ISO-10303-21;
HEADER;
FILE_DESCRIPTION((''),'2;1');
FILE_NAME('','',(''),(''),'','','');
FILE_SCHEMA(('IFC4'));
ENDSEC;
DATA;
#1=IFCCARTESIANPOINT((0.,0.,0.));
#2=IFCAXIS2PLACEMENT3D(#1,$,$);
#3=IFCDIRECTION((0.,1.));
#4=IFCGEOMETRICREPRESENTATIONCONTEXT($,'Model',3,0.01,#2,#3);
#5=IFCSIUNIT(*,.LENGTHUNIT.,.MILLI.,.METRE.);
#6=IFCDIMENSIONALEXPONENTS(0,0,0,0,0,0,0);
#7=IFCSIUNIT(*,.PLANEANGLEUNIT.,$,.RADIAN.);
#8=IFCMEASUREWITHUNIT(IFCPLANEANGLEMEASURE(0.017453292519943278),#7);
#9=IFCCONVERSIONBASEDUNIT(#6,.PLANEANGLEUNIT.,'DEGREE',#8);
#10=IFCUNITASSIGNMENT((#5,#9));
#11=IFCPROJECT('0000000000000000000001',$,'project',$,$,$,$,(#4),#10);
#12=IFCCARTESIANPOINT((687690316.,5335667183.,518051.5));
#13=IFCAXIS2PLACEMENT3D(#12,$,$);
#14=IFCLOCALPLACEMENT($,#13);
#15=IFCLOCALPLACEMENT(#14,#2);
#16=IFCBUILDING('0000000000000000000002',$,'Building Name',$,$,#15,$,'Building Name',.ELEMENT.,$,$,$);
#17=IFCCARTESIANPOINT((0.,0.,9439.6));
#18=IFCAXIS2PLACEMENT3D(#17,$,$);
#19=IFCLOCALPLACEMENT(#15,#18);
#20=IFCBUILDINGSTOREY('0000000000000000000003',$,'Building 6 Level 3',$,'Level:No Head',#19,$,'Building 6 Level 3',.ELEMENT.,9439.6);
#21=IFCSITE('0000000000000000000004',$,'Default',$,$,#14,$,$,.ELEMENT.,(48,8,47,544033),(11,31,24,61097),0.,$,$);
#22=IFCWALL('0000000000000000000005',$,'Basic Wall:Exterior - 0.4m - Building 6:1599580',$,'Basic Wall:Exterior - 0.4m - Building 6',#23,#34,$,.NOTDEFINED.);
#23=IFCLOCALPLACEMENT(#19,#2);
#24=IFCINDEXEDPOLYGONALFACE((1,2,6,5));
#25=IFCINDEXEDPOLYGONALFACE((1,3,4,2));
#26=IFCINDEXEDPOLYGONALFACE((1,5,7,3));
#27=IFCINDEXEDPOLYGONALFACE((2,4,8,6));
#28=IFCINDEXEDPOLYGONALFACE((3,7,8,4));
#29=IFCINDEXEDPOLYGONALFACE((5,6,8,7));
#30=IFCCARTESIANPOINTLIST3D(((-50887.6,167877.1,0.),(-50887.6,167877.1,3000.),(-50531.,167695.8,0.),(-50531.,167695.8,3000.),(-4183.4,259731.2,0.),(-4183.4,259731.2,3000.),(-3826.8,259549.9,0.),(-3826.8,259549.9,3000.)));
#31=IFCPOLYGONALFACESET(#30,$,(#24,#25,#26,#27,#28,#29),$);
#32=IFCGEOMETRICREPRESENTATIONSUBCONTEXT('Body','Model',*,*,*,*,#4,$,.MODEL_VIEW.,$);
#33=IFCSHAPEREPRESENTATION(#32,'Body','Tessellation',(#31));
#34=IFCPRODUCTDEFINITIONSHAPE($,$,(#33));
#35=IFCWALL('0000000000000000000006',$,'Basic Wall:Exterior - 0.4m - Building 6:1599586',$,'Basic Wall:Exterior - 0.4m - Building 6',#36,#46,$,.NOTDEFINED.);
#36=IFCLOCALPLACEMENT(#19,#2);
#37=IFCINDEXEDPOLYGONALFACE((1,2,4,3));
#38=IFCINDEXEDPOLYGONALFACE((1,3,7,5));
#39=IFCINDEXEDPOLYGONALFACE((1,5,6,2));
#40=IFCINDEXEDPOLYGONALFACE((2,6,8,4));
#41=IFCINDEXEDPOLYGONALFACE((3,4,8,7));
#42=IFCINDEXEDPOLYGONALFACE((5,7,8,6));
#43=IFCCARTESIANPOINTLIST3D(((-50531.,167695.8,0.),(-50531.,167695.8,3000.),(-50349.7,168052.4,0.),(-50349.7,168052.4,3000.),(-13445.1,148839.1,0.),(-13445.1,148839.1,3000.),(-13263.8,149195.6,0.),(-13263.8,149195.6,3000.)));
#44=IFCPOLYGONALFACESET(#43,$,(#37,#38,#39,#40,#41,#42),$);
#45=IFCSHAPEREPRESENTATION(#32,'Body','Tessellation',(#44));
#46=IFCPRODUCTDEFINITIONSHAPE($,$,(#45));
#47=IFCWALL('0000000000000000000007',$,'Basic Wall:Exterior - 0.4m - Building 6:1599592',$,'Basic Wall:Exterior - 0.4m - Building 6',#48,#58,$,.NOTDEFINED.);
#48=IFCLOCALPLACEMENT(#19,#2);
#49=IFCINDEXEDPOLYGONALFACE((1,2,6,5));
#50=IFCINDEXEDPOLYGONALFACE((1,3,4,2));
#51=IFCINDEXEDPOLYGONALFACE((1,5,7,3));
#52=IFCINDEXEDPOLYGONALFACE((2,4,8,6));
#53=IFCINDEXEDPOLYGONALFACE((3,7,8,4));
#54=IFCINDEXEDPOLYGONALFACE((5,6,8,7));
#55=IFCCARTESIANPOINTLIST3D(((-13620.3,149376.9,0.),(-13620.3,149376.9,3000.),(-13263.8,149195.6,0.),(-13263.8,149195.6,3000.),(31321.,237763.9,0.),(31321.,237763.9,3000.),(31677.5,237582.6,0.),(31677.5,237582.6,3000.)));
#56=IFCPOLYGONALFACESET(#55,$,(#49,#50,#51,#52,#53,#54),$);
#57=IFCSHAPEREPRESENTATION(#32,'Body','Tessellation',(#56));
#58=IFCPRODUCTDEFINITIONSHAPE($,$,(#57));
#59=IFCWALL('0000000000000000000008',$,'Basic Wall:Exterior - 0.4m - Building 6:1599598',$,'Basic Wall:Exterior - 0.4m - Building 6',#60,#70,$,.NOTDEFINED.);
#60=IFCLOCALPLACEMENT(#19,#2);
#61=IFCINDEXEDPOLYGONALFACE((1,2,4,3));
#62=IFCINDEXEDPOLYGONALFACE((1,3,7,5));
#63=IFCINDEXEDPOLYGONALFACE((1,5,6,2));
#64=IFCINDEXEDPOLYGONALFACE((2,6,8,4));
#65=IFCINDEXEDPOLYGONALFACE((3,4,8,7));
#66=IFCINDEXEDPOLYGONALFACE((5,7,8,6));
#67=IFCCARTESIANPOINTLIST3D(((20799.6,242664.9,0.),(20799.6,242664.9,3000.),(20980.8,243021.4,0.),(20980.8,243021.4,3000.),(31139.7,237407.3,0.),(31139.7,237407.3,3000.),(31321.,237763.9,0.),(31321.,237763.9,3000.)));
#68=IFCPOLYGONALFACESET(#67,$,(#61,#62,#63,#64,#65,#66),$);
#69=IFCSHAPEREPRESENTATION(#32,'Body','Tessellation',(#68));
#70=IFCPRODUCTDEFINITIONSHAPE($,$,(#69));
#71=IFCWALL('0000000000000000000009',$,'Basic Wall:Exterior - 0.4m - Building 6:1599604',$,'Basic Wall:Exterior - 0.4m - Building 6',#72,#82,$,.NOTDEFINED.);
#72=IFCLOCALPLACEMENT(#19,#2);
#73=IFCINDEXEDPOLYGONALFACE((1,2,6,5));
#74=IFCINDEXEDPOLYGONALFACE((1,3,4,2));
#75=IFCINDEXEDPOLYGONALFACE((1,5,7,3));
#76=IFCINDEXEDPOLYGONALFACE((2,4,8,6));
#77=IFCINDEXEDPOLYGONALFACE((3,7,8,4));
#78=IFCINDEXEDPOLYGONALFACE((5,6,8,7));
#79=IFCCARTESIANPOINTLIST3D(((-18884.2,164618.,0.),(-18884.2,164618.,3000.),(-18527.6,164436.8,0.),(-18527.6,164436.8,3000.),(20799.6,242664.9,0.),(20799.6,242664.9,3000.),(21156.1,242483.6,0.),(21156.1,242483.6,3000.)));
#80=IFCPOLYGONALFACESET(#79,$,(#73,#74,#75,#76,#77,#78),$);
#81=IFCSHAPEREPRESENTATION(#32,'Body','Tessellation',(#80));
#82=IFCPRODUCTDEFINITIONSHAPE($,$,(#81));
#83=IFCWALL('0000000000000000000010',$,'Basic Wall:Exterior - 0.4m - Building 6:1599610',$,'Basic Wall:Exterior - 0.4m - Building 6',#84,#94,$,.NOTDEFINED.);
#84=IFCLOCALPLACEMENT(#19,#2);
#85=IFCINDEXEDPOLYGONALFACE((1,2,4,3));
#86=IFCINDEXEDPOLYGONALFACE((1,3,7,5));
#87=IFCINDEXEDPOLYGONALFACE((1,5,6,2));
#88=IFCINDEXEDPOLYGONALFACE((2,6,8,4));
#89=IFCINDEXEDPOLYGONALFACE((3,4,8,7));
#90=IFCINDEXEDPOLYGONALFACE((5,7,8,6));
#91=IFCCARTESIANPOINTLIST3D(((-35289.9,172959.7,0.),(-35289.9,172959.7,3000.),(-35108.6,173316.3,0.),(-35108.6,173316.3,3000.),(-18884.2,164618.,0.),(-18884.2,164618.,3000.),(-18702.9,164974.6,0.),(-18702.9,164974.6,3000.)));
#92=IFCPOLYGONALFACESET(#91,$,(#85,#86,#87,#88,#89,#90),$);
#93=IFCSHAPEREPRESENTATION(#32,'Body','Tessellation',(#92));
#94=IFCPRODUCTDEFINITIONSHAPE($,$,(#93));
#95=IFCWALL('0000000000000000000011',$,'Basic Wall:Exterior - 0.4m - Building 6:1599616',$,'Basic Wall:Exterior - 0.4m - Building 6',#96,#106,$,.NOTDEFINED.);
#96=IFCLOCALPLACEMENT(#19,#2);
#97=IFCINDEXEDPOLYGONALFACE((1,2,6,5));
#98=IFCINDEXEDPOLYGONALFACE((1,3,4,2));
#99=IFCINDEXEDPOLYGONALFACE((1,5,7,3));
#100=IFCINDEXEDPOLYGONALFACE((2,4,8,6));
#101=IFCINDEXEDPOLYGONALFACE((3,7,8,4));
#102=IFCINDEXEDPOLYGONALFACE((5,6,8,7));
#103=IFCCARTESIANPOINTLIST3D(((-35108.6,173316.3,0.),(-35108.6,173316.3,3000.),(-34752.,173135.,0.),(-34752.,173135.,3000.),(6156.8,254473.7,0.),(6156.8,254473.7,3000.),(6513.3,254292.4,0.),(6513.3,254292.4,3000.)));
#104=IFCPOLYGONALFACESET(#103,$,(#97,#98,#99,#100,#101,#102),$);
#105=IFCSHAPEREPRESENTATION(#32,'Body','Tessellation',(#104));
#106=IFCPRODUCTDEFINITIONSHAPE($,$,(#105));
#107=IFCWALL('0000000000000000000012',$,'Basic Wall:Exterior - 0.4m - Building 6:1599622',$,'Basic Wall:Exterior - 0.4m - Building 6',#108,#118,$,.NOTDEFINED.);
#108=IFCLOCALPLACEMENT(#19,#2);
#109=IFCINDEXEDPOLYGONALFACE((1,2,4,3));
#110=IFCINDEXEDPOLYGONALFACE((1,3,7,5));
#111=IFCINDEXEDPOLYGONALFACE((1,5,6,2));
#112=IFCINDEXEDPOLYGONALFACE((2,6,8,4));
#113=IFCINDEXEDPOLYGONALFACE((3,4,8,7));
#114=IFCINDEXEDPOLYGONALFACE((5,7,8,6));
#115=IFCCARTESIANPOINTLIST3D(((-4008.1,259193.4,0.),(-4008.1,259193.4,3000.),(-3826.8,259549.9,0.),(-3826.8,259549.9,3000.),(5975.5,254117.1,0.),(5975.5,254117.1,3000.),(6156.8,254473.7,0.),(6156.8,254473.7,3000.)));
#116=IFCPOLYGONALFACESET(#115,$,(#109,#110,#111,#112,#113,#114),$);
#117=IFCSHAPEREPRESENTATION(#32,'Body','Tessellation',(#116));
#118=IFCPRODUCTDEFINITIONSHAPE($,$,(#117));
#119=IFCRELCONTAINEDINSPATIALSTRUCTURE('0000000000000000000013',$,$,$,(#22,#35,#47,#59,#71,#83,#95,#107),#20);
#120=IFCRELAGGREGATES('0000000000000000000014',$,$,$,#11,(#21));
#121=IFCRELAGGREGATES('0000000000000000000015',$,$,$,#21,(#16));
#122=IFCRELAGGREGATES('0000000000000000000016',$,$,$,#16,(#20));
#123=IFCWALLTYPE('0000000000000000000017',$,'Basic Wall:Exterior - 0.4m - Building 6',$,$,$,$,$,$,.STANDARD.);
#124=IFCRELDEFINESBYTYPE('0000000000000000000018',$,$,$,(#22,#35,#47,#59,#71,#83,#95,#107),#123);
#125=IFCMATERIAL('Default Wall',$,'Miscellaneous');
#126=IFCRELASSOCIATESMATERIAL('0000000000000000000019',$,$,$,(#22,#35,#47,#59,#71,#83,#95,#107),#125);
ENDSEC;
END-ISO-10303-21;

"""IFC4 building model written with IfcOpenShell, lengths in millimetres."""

from ifc_helpers import new_model, entity, si_unit, converted_unit, direction, frame, origin, place, context, subcontext, project, spatial, indexed_curve, outline, extrude, material, type_object, element, save


model = new_model("IFC4")

# Units and contexts
model_context = context("Model", 3, precision=0.01, world=origin(), true_north=direction((0.0, 1.0)))
body_context = subcontext(model_context, "Body", "Model", "MODEL_VIEW")
ifc_project = project(units=[si_unit("LENGTHUNIT", "METRE", prefix="MILLI"), converted_unit("PLANEANGLEUNIT", "DEGREE", entity("IfcPlaneAngleMeasure", 0.017453292519943278), si_unit("PLANEANGLEUNIT", "RADIAN"), dimensions=[0, 0, 0, 0, 0, 0, 0])], contexts=[model_context])

# Site, building, storey
site_placement = place(None, frame((687690316.0, 5335667183.0, 518051.5)))
site = spatial("IfcSite", under=ifc_project, at=site_placement, Name="Default", CompositionType="ELEMENT", RefLatitude=(48, 8, 47, 544033), RefLongitude=(11, 31, 24, 61097), RefElevation=0.0)
building_placement = place(site_placement, origin())
building = spatial("IfcBuilding", under=site, at=building_placement, Name="Building Name", LongName="Building Name", CompositionType="ELEMENT")
storey_placement = place(building_placement, frame((0.0, 0.0, 9439.6)))
storey = spatial("IfcBuildingStorey", under=building, at=storey_placement, Name="Building 6 Level 3", ObjectType="Level:No Head", LongName="Building 6 Level 3", CompositionType="ELEMENT", Elevation=9439.6)

# Walls
ifc_material_1 = material(Name="Default Wall", Category="Miscellaneous")
wall_type = type_object("IfcWallType", Name="Basic Wall:Exterior - 0.4m - Building 6", PredefinedType="STANDARD")
wall_1_placement = place(storey_placement, frame((-4005.1, 259640.6, 0.0), z_axis=(0.0, 0.0, 1.0), x_axis=(-0.453237, -0.89139, 0.0)))
element("IfcWall", 1, at=wall_1_placement, inside=storey, type_object=wall_type, material=ifc_material_1, Name="Basic Wall:Exterior - 0.4m - Building 6:1599580", ObjectType="Basic Wall:Exterior - 0.4m - Building 6", PredefinedType="NOTDEFINED", context=body_context, shape_type="SweptSolid", body=[
    extrude(outline(indexed_curve([(103045.9, 200.0), (0.0, 200.0), (0.0, -200.0), (103045.9, -200.0), (103045.9, 200.0)], self_intersect=False)), origin(), (0.0, 0.0, 1.0), 3000.0),
])
wall_2_placement = place(storey_placement, frame((-50440.4, 167874.1, 0.0), z_axis=(0.0, 0.0, 1.0), x_axis=(0.89139, -0.453237, 0.0)))
element("IfcWall", 2, at=wall_2_placement, inside=storey, type_object=wall_type, material=ifc_material_1, Name="Basic Wall:Exterior - 0.4m - Building 6:1599586", ObjectType="Basic Wall:Exterior - 0.4m - Building 6", PredefinedType="NOTDEFINED", context=body_context, shape_type="SweptSolid", body=[
    extrude(outline(indexed_curve([(41604.6, 200.0), (0.0, 200.0), (0.0, -200.0), (41604.6, -200.0), (41604.6, 200.0)], self_intersect=False)), origin(), (0.0, 0.0, 1.0), 3000.0),
])
wall_3_placement = place(storey_placement, frame((-13442.0, 149286.3, 0.0), z_axis=(0.0, 0.0, 1.0), x_axis=(0.453237, 0.89139, 0.0)))
element("IfcWall", 3, at=wall_3_placement, inside=storey, type_object=wall_type, material=ifc_material_1, Name="Basic Wall:Exterior - 0.4m - Building 6:1599592", ObjectType="Basic Wall:Exterior - 0.4m - Building 6", PredefinedType="NOTDEFINED", context=body_context, shape_type="SweptSolid", body=[
    extrude(outline(indexed_curve([(99156.3, 200.0), (0.0, 200.0), (0.0, -200.0), (99156.3, -200.0), (99156.3, 200.0)], self_intersect=False)), origin(), (0.0, 0.0, 1.0), 3000.0),
])
wall_4_placement = place(storey_placement, frame((31230.3, 237585.6, 0.0), z_axis=(0.0, 0.0, 1.0), x_axis=(-0.89139, 0.453237, 0.0)))
element("IfcWall", 4, at=wall_4_placement, inside=storey, type_object=wall_type, material=ifc_material_1, Name="Basic Wall:Exterior - 0.4m - Building 6:1599598", ObjectType="Basic Wall:Exterior - 0.4m - Building 6", PredefinedType="NOTDEFINED", context=body_context, shape_type="SweptSolid", body=[
    extrude(outline(indexed_curve([(11600.0, 200.0), (0.0, 200.0), (0.0, -200.0), (11600.0, -200.0), (11600.0, 200.0)], self_intersect=False)), origin(), (0.0, 0.0, 1.0), 3000.0),
])
wall_5_placement = place(storey_placement, frame((20977.8, 242574.2, 0.0), z_axis=(0.0, 0.0, 1.0), x_axis=(-0.453237, -0.89139, 0.0)))
element("IfcWall", 5, at=wall_5_placement, inside=storey, type_object=wall_type, material=ifc_material_1, Name="Basic Wall:Exterior - 0.4m - Building 6:1599604", ObjectType="Basic Wall:Exterior - 0.4m - Building 6", PredefinedType="NOTDEFINED", context=body_context, shape_type="SweptSolid", body=[
    extrude(outline(indexed_curve([(87556.3, 200.0), (0.0, 200.0), (0.0, -200.0), (87556.3, -200.0), (87556.3, 200.0)], self_intersect=False)), origin(), (0.0, 0.0, 1.0), 3000.0),
])
wall_6_placement = place(storey_placement, frame((-18793.5, 164796.3, 0.0), z_axis=(0.0, 0.0, 1.0), x_axis=(-0.89139, 0.453237, 0.0)))
element("IfcWall", 6, at=wall_6_placement, inside=storey, type_object=wall_type, material=ifc_material_1, Name="Basic Wall:Exterior - 0.4m - Building 6:1599610", ObjectType="Basic Wall:Exterior - 0.4m - Building 6", PredefinedType="NOTDEFINED", context=body_context, shape_type="SweptSolid", body=[
    extrude(outline(indexed_curve([(18404.6, 200.0), (0.0, 200.0), (0.0, -200.0), (18404.6, -200.0), (18404.6, 200.0)], self_intersect=False)), origin(), (0.0, 0.0, 1.0), 3000.0),
])
wall_7_placement = place(storey_placement, frame((-34930.3, 173225.6, 0.0), z_axis=(0.0, 0.0, 1.0), x_axis=(0.453237, 0.89139, 0.0)))
element("IfcWall", 7, at=wall_7_placement, inside=storey, type_object=wall_type, material=ifc_material_1, Name="Basic Wall:Exterior - 0.4m - Building 6:1599616", ObjectType="Basic Wall:Exterior - 0.4m - Building 6", PredefinedType="NOTDEFINED", context=body_context, shape_type="SweptSolid", body=[
    extrude(outline(indexed_curve([(91045.9, 200.0), (0.0, 200.0), (0.0, -200.0), (91045.9, -200.0), (91045.9, 200.0)], self_intersect=False)), origin(), (0.0, 0.0, 1.0), 3000.0),
])
wall_8_placement = place(storey_placement, frame((6066.1, 254295.4, 0.0), z_axis=(0.0, 0.0, 1.0), x_axis=(-0.89139, 0.453237, 0.0)))
element("IfcWall", 8, at=wall_8_placement, inside=storey, type_object=wall_type, material=ifc_material_1, Name="Basic Wall:Exterior - 0.4m - Building 6:1599622", ObjectType="Basic Wall:Exterior - 0.4m - Building 6", PredefinedType="NOTDEFINED", context=body_context, shape_type="SweptSolid", body=[
    extrude(outline(indexed_curve([(11200.0, 200.0), (0.0, 200.0), (0.0, -200.0), (11200.0, -200.0), (11200.0, 200.0)], self_intersect=False)), origin(), (0.0, 0.0, 1.0), 3000.0),
])

save(model, "model.ifc")
